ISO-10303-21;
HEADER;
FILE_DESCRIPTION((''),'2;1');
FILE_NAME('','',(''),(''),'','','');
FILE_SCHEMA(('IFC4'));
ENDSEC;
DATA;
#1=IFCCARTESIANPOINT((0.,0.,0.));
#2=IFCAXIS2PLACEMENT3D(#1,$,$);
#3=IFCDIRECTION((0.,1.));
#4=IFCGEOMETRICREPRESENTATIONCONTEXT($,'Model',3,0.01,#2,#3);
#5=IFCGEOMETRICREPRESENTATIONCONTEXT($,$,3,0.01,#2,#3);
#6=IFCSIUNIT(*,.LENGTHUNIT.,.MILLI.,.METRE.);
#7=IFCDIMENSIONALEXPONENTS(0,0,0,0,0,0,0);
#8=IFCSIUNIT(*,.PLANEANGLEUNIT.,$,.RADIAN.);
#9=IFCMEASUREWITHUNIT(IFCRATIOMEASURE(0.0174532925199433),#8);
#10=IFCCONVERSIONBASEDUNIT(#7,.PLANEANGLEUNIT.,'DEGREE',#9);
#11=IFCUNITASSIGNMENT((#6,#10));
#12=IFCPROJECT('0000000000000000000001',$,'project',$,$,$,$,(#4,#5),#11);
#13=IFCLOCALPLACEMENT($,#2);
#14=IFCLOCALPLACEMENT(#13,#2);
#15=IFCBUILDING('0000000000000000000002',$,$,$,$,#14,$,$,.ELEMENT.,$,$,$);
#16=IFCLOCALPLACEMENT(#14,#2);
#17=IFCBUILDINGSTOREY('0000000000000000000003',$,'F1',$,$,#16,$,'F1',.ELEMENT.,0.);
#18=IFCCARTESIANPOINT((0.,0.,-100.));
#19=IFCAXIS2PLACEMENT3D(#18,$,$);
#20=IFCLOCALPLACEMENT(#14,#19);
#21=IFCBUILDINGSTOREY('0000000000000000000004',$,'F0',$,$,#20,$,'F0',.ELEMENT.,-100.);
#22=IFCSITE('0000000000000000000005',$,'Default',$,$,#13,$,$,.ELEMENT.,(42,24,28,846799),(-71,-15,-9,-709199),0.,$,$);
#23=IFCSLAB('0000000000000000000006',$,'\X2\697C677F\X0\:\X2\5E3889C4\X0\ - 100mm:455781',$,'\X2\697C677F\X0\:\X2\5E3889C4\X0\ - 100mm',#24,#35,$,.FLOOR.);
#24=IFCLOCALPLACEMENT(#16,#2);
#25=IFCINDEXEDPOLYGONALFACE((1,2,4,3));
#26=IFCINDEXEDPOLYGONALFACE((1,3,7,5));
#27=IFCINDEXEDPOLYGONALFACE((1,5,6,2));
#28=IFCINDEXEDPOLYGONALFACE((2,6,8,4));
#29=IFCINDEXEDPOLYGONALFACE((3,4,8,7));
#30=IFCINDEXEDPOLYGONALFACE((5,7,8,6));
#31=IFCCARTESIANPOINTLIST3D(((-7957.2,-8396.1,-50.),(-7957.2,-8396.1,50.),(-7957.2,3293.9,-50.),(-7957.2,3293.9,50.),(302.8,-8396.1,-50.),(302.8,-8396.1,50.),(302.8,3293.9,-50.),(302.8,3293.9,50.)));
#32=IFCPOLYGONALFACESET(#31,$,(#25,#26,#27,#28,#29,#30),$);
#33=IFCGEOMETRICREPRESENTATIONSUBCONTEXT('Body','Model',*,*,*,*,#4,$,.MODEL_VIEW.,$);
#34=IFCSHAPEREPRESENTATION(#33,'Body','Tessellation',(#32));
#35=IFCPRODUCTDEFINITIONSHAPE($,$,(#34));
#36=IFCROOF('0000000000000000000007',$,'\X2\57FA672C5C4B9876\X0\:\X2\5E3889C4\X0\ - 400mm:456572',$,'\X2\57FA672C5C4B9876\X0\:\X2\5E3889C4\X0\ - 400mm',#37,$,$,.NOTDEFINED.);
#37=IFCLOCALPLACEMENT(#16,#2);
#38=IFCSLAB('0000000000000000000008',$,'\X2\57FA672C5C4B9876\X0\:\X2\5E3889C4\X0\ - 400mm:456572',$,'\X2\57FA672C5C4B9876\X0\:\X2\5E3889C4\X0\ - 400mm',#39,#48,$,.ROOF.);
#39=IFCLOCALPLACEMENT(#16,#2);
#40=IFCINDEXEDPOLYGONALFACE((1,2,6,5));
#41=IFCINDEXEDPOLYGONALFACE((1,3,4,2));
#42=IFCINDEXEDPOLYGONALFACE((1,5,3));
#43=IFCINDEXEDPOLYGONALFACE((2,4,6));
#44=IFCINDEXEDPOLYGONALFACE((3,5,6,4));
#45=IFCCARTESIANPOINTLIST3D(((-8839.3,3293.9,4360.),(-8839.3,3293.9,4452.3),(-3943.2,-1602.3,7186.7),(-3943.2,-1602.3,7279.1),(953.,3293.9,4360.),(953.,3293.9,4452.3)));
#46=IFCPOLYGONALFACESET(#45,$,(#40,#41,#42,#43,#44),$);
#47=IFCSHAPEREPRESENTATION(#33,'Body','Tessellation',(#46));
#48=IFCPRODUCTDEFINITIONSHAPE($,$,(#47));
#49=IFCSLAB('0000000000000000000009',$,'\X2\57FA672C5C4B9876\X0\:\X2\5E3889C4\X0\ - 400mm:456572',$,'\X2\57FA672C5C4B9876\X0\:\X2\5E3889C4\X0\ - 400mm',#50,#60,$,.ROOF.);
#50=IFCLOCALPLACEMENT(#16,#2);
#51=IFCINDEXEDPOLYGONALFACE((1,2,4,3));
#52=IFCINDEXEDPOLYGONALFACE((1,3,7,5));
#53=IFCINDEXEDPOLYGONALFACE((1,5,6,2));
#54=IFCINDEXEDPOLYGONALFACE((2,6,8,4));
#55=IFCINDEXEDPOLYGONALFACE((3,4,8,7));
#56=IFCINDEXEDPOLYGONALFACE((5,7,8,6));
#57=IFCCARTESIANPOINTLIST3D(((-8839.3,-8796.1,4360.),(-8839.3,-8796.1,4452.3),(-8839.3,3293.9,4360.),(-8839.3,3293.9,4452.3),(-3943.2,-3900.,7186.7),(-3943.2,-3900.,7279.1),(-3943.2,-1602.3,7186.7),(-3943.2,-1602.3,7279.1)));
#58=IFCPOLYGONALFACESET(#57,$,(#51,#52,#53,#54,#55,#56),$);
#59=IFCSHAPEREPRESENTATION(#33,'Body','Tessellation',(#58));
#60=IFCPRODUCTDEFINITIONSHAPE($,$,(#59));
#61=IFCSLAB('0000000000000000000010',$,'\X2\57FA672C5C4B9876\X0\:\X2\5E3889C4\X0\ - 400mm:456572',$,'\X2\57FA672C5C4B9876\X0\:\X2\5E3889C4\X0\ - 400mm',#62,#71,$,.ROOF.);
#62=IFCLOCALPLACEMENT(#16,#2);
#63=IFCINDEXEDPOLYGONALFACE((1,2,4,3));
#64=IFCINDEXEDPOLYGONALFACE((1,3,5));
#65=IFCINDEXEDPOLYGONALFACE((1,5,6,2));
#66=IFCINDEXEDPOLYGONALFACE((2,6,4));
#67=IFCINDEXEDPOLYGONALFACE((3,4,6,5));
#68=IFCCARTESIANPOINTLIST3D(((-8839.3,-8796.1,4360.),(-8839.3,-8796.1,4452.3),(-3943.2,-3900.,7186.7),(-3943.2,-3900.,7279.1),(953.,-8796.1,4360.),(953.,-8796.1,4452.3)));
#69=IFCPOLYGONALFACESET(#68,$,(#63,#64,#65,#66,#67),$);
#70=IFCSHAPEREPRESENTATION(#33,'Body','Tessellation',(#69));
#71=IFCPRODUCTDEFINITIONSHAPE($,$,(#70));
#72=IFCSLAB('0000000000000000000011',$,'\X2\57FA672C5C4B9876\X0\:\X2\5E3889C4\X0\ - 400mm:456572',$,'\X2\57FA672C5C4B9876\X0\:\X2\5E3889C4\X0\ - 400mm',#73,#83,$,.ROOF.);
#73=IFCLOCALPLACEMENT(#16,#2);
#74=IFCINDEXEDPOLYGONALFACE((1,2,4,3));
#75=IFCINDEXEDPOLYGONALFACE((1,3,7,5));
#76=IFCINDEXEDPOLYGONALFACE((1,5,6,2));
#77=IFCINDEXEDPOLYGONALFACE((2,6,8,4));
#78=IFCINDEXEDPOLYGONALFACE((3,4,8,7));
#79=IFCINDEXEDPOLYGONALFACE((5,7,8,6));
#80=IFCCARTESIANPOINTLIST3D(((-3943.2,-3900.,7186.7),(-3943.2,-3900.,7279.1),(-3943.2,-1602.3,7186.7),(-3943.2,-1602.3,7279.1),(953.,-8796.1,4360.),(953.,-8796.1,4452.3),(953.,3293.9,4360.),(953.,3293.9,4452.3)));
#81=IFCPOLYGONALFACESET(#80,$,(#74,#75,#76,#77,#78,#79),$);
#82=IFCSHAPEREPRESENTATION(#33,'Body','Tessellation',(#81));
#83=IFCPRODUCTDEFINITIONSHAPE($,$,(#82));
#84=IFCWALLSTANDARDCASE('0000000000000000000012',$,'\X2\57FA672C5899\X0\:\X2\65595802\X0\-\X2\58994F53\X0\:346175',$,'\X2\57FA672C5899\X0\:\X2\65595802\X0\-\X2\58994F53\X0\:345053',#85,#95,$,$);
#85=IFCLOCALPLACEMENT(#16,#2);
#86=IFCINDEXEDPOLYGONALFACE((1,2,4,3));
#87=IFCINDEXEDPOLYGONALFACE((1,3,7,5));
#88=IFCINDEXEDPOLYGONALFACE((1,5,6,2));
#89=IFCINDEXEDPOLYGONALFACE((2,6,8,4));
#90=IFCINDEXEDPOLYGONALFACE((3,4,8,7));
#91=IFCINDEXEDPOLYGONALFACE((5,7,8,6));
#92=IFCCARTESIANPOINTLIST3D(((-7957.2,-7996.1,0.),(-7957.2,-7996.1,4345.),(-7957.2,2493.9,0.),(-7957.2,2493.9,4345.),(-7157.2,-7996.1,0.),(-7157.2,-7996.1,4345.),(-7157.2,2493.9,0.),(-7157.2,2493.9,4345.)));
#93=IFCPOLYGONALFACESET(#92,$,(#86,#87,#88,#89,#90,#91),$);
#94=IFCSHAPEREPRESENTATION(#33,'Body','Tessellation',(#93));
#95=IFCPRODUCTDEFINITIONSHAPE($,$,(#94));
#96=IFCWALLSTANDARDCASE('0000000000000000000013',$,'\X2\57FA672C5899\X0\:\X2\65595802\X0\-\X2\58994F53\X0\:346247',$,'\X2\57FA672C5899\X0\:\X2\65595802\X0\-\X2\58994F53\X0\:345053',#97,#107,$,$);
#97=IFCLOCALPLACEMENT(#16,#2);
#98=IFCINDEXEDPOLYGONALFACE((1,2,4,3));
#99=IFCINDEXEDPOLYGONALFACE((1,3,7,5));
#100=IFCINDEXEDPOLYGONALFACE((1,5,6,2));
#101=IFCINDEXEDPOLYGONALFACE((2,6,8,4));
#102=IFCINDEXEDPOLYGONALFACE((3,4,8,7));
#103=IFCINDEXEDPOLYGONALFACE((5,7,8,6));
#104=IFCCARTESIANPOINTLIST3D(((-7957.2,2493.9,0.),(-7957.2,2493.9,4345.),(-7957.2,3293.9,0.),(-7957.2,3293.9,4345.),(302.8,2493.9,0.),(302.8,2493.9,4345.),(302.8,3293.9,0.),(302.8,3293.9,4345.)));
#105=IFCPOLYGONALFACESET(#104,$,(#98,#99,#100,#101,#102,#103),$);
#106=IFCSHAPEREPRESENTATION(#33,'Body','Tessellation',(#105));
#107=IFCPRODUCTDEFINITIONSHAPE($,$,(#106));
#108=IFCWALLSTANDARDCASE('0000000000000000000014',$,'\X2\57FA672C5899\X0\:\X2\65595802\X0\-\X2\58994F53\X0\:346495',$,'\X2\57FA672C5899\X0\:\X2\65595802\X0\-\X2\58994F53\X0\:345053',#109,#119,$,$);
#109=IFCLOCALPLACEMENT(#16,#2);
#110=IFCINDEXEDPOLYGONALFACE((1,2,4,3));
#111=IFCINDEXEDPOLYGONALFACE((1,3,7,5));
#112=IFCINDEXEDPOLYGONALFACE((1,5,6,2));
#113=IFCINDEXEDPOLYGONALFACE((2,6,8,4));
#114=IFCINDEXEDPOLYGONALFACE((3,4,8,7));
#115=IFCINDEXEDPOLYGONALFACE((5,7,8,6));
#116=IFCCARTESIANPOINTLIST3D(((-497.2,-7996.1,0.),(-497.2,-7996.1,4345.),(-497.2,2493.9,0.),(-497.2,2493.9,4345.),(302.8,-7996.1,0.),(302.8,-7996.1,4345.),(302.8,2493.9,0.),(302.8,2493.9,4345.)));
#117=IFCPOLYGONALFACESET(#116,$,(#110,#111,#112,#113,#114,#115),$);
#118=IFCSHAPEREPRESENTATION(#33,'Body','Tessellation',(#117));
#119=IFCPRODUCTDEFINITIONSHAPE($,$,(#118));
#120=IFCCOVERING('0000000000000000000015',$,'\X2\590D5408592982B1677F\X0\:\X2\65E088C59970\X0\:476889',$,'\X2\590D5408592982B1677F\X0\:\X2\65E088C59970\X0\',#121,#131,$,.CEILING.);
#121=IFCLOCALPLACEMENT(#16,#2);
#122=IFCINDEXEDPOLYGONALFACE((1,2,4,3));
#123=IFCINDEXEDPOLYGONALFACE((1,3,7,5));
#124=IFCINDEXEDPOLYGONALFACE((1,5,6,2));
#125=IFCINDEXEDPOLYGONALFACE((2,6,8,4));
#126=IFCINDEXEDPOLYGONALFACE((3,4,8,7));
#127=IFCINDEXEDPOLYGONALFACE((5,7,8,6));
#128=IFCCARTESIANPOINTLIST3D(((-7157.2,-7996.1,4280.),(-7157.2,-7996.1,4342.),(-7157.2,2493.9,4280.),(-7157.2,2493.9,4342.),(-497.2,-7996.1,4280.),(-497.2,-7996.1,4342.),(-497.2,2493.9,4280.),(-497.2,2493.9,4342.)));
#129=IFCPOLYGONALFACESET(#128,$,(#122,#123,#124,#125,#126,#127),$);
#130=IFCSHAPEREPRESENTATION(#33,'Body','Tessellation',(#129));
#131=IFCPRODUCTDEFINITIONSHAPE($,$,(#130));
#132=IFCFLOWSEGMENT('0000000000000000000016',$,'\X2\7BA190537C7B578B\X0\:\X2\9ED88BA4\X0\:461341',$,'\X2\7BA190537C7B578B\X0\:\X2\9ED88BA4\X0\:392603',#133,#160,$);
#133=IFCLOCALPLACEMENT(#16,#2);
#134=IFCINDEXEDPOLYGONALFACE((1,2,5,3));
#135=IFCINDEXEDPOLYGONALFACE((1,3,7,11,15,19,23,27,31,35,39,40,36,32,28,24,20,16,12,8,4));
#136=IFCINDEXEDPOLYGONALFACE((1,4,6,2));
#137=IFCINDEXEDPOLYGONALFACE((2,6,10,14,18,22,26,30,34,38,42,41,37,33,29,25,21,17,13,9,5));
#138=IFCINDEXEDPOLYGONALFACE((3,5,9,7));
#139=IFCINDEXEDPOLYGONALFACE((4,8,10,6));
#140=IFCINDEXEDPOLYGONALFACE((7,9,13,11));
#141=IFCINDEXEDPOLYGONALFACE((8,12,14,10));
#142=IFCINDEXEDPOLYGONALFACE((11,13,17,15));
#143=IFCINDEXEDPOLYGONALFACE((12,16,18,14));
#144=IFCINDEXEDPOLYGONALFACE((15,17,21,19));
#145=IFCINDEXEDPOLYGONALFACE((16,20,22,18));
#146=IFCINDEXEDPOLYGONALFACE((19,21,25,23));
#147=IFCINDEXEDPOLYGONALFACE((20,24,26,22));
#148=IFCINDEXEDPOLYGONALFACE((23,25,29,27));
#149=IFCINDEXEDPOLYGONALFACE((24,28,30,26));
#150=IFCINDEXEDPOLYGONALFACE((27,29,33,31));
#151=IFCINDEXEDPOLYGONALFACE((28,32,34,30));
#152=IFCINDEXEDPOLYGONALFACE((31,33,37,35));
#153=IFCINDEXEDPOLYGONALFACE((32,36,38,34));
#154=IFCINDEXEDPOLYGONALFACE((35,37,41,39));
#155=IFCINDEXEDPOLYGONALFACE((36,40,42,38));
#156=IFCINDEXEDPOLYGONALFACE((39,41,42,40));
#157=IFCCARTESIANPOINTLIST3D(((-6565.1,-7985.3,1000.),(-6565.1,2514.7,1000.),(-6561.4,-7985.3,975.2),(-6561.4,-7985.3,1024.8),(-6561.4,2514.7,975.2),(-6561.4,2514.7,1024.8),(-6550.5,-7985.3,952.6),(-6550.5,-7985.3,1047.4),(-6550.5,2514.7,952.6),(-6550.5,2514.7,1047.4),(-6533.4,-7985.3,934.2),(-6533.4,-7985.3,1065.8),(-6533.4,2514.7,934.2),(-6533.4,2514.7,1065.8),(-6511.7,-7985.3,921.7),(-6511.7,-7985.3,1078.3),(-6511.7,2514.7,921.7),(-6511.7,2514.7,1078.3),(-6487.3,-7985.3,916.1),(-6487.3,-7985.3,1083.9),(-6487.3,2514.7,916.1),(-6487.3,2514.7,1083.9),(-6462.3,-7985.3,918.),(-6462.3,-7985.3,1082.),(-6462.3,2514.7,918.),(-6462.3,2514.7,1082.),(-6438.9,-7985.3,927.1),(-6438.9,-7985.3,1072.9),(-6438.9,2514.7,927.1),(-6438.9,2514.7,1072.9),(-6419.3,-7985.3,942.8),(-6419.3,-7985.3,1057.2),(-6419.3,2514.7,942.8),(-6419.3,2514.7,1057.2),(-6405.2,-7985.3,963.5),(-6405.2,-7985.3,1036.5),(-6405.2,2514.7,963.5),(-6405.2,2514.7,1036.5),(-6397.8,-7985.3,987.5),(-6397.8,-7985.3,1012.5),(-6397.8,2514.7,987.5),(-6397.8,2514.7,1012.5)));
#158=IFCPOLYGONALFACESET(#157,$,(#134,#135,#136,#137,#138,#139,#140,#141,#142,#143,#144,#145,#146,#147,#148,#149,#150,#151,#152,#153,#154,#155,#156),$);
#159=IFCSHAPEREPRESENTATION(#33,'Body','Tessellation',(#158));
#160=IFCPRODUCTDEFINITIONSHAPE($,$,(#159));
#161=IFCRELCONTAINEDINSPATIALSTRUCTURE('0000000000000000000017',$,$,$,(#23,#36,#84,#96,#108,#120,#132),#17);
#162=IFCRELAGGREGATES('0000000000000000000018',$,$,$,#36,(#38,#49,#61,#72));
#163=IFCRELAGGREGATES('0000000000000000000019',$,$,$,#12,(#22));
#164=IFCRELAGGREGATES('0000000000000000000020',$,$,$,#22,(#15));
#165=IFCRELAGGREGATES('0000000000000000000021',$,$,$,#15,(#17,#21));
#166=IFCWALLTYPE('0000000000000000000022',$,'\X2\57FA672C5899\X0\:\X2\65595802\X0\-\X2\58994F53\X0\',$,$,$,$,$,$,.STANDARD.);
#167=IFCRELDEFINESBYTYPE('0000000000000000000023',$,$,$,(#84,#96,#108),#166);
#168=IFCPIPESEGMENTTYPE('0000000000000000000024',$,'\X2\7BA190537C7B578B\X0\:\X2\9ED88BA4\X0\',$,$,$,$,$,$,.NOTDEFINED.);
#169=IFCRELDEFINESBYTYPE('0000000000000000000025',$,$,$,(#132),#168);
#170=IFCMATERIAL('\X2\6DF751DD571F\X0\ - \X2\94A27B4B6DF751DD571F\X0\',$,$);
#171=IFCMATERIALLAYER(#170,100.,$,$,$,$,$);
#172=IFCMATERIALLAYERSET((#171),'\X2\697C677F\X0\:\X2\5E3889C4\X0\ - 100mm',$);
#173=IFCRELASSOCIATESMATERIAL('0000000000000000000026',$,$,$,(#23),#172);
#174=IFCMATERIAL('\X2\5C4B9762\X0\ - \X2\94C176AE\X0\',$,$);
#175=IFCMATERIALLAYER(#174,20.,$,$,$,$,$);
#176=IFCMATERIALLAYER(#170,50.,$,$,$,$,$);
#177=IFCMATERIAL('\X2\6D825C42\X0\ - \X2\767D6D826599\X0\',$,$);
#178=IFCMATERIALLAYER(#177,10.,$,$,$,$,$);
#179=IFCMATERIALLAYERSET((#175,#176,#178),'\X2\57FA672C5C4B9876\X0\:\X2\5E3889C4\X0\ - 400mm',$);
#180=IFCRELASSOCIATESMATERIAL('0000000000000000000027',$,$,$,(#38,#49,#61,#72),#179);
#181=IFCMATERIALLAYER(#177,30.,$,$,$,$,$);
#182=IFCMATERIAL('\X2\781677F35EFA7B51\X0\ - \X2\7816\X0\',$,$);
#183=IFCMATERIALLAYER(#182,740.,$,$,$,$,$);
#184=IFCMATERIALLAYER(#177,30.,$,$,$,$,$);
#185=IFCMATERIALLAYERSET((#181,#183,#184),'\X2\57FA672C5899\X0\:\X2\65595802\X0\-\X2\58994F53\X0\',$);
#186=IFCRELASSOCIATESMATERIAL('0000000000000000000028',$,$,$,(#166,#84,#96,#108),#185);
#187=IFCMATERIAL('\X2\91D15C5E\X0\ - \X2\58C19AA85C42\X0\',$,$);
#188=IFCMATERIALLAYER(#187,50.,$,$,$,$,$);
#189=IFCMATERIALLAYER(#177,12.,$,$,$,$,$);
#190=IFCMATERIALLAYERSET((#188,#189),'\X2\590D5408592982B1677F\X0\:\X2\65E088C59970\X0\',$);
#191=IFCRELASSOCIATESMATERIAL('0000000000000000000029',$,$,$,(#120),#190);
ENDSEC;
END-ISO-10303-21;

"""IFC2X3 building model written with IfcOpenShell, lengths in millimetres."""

from ifc_helpers import new_model, entity, si_unit, converted_unit, direction, frame, frame_2d, origin, origin_2d_with_axis, place, context, subcontext, project, spatial, polyline, rectangle, circle, outline, extrude, material, layer, layer_set, layer_usage, type_object, element, aggregate, save


model = new_model("IFC2X3")

# Units and contexts
model_context = context("Model", 3, precision=0.01, world=origin(), true_north=direction((0.0, 1.0)))
context_of_model = context(None, 3, precision=0.01, world=origin(), true_north=direction((0.0, 1.0)))
body_context = subcontext(model_context, "Body", "Model", "MODEL_VIEW")
ifc_project = project(units=[si_unit("LENGTHUNIT", "METRE", prefix="MILLI"), converted_unit("PLANEANGLEUNIT", "DEGREE", entity("IfcRatioMeasure", 0.0174532925199433), si_unit("PLANEANGLEUNIT", "RADIAN"), dimensions=[0, 0, 0, 0, 0, 0, 0])], contexts=[model_context, context_of_model])

# Site, building, storey
site_placement = place(None, origin())
site = spatial("IfcSite", under=ifc_project, at=site_placement, Name="Default", CompositionType="ELEMENT", RefLatitude=(42, 24, 28, 846799), RefLongitude=(-71, -15, -9, -709199), RefElevation=0.0)
building_placement = place(site_placement, origin())
building = spatial("IfcBuilding", under=site, at=building_placement, CompositionType="ELEMENT")
storey_1_placement = place(building_placement, origin())
storey_1 = spatial("IfcBuildingStorey", under=building, at=storey_1_placement, Name="F1", LongName="F1", CompositionType="ELEMENT", Elevation=0.0)

# Slab
ifc_material_1 = material(Name="混凝土 - 钢筋混凝土")
ifc_layer_1 = layer(ifc_material_1, 100.0)
ifc_layer_set_1 = layer_set([ifc_layer_1], Name="楼板:常规 - 100mm")
ifc_layer_usage_1 = layer_usage(ifc_layer_set_1, "AXIS3", "POSITIVE", 0.0)
slab_1_placement = place(storey_1_placement, origin())
element("IfcSlab", 1, at=slab_1_placement, inside=storey_1, material=ifc_layer_usage_1, Name="楼板:常规 - 100mm:455781", ObjectType="楼板:常规 - 100mm", PredefinedType="FLOOR", context=body_context, shape_type="SweptSolid", body=[
    extrude(rectangle(XDim=11690.0, YDim=8260.0, at=origin_2d_with_axis()), frame((-3827.2, -2551.1, 50.0), z_axis=(0.0, 0.0, -1.0), x_axis=(0.0, 1.0, 0.0)), (0.0, 0.0, 1.0), 100.0),
])

# Roof, slabs
roof_placement = place(storey_1_placement, frame((-8839.3, -8796.1, 4360.0)))
roof = element("IfcRoof", 2, at=roof_placement, inside=storey_1, Name="基本屋顶:常规 - 400mm:456572", ObjectType="基本屋顶:常规 - 400mm", ShapeType="NOTDEFINED")
ifc_material_2 = material(Name="屋面 - 铁皮")
ifc_layer_2 = layer(ifc_material_2, 20.0)
ifc_layer_3 = layer(ifc_material_1, 50.0)
ifc_material_3 = material(Name="涂层 - 白涂料")
ifc_layer_4 = layer(ifc_material_3, 10.0)
ifc_layer_set_2 = layer_set([ifc_layer_2, ifc_layer_3, ifc_layer_4], Name="基本屋顶:常规 - 400mm")
slab_2_placement = place(roof_placement, origin())
slab_2 = element("IfcSlab", 3, at=slab_2_placement, material=ifc_layer_set_2, Name="基本屋顶:常规 - 400mm:456572", ObjectType="基本屋顶:常规 - 400mm", PredefinedType="ROOF", context=body_context, shape_type="SweptSolid", body=[
    extrude(outline(polyline([(4896.1, 2826.8), (-4896.1, 2826.8), (0.0, -2826.8), (4896.1, 2826.8)])), frame((4896.1, 9641.9, 1413.4), z_axis=(0.0, 0.5, 0.866025), x_axis=(1.0, 0.0, 0.0)), (0.0, -0.5, 0.866025), 92.4),
])
slab_3_placement = place(roof_placement, origin())
slab_3 = element("IfcSlab", 4, at=slab_3_placement, material=ifc_layer_set_2, Name="基本屋顶:常规 - 400mm:456572", ObjectType="基本屋顶:常规 - 400mm", PredefinedType="ROOF", context=body_context, shape_type="SweptSolid", body=[
    extrude(outline(polyline([(-2826.8, 6045.0), (-2826.8, -6045.0), (2826.8, -1148.9), (2826.8, 1148.9), (-2826.8, 6045.0)])), frame((2448.1, 6045.0, 1413.4), z_axis=(-0.5, 0.0, 0.866025), x_axis=(0.866025, 0.0, 0.5)), (0.5, 0.0, 0.866025), 92.4),
])
slab_4_placement = place(roof_placement, origin())
slab_4 = element("IfcSlab", 5, at=slab_4_placement, material=ifc_layer_set_2, Name="基本屋顶:常规 - 400mm:456572", ObjectType="基本屋顶:常规 - 400mm", PredefinedType="ROOF", context=body_context, shape_type="SweptSolid", body=[
    extrude(outline(polyline([(-4896.1, -2826.8), (4896.1, -2826.8), (0.0, 2826.8), (-4896.1, -2826.8)])), frame((4896.1, 2448.1, 1413.4), z_axis=(0.0, -0.5, 0.866025), x_axis=(1.0, 0.0, 0.0)), (0.0, 0.5, 0.866025), 92.4),
])
slab_5_placement = place(roof_placement, origin())
slab_5 = element("IfcSlab", 6, at=slab_5_placement, material=ifc_layer_set_2, Name="基本屋顶:常规 - 400mm:456572", ObjectType="基本屋顶:常规 - 400mm", PredefinedType="ROOF", context=body_context, shape_type="SweptSolid", body=[
    extrude(outline(polyline([(-2826.8, 1148.9), (-2826.8, -1148.9), (2826.8, -6045.0), (2826.8, 6045.0), (-2826.8, 1148.9)])), frame((7344.2, 6045.0, 1413.4), z_axis=(0.5, 0.0, 0.866025), x_axis=(0.866025, 0.0, -0.5)), (-0.5, 0.0, 0.866025), 92.4),
])
aggregate(roof, [slab_2, slab_3, slab_4, slab_5])

# Walls
ifc_layer_5 = layer(ifc_material_3, 30.0)
ifc_material_4 = material(Name="砖石建筑 - 砖")
ifc_layer_6 = layer(ifc_material_4, 740.0)
ifc_layer_7 = layer(ifc_material_3, 30.0)
ifc_layer_set_3 = layer_set([ifc_layer_5, ifc_layer_6, ifc_layer_7], Name="基本墙:教堂-墙体")
ifc_layer_usage_2 = layer_usage(ifc_layer_set_3, "AXIS2", "NEGATIVE", 400.0)
wall_type = type_object("IfcWallType", Name="基本墙:教堂-墙体", PredefinedType="STANDARD", material=ifc_layer_set_3)
wall_1_placement = place(storey_1_placement, frame((-7557.2, -7996.1, 0.0), z_axis=(0.0, 0.0, 1.0), x_axis=(0.0, 1.0, 0.0)))
element("IfcWallStandardCase", 7, at=wall_1_placement, inside=storey_1, type_object=wall_type, material=ifc_layer_usage_2, Name="基本墙:教堂-墙体:346175", ObjectType="基本墙:教堂-墙体:345053", context=body_context, shape_type="SweptSolid", body=[
    extrude(rectangle(XDim=10490.0, YDim=800.0, at=frame_2d((5245.0, 0.0), x_axis=(-1.0, 0.0))), origin(), (0.0, 0.0, 1.0), 4345.0),
])
ifc_layer_usage_3 = layer_usage(ifc_layer_set_3, "AXIS2", "NEGATIVE", 400.0)
wall_2_placement = place(storey_1_placement, frame((-7957.2, 2893.9, 0.0)))
element("IfcWallStandardCase", 8, at=wall_2_placement, inside=storey_1, type_object=wall_type, material=ifc_layer_usage_3, Name="基本墙:教堂-墙体:346247", ObjectType="基本墙:教堂-墙体:345053", context=body_context, shape_type="SweptSolid", body=[
    extrude(rectangle(XDim=8260.0, YDim=800.0, at=frame_2d((4130.0, 0.0), x_axis=(-1.0, 0.0))), origin(), (0.0, 0.0, 1.0), 4345.0),
])
ifc_layer_usage_4 = layer_usage(ifc_layer_set_3, "AXIS2", "NEGATIVE", 400.0)
wall_3_placement = place(storey_1_placement, frame((-97.2, 2493.9, 0.0), z_axis=(0.0, 0.0, 1.0), x_axis=(0.0, -1.0, 0.0)))
element("IfcWallStandardCase", 9, at=wall_3_placement, inside=storey_1, type_object=wall_type, material=ifc_layer_usage_4, Name="基本墙:教堂-墙体:346495", ObjectType="基本墙:教堂-墙体:345053", context=body_context, shape_type="SweptSolid", body=[
    extrude(rectangle(XDim=10490.0, YDim=800.0, at=frame_2d((5245.0, 0.0), x_axis=(-1.0, 0.0))), origin(), (0.0, 0.0, 1.0), 4345.0),
])

# Shared definitions
storey_2_placement = place(building_placement, frame((0.0, 0.0, -100.0)))
storey_2 = spatial("IfcBuildingStorey", under=building, at=storey_2_placement, Name="F0", LongName="F0", CompositionType="ELEMENT", Elevation=-100.0)

# Covering
ifc_material_5 = material(Name="金属 - 壁骨层")
ifc_layer_8 = layer(ifc_material_5, 50.0)
ifc_layer_9 = layer(ifc_material_3, 12.0)
ifc_layer_set_4 = layer_set([ifc_layer_8, ifc_layer_9], Name="复合天花板:无装饰")
ifc_layer_usage_5 = layer_usage(ifc_layer_set_4, "AXIS3", "NEGATIVE", 0.0)
covering_placement = place(storey_1_placement, origin())
element("IfcCovering", 10, at=covering_placement, inside=storey_1, material=ifc_layer_usage_5, Name="复合天花板:无装饰:476889", ObjectType="复合天花板:无装饰", PredefinedType="CEILING", context=body_context, shape_type="SweptSolid", body=[
    extrude(rectangle(XDim=6660.0, YDim=10490.0, at=frame_2d((0.0, 0.0), x_axis=(1.0, 0.0))), frame((-3827.2, -2751.1, 4280.0)), (0.0, 0.0, 1.0), 62.0),
])

# Flow segment
pipe_segment_type = type_object("IfcPipeSegmentType", Name="管道类型:默认", PredefinedType="NOTDEFINED")
flow_segment_placement = place(storey_1_placement, origin())
element("IfcFlowSegment", 11, at=flow_segment_placement, inside=storey_1, type_object=pipe_segment_type, Name="管道类型:默认:461341", ObjectType="管道类型:默认:392603", context=body_context, shape_type="SweptSolid", body=[
    extrude(circle(Radius=84.1, at=frame_2d((0.0, 0.0), x_axis=(1.0, 0.0))), frame((-6481.0, -7985.3, 1000.0), z_axis=(0.0, 1.0, 0.0), x_axis=(-1.0, 0.0, 0.0)), (0.0, 0.0, 1.0), 10500.0),
])

save(model, "model.ifc")
